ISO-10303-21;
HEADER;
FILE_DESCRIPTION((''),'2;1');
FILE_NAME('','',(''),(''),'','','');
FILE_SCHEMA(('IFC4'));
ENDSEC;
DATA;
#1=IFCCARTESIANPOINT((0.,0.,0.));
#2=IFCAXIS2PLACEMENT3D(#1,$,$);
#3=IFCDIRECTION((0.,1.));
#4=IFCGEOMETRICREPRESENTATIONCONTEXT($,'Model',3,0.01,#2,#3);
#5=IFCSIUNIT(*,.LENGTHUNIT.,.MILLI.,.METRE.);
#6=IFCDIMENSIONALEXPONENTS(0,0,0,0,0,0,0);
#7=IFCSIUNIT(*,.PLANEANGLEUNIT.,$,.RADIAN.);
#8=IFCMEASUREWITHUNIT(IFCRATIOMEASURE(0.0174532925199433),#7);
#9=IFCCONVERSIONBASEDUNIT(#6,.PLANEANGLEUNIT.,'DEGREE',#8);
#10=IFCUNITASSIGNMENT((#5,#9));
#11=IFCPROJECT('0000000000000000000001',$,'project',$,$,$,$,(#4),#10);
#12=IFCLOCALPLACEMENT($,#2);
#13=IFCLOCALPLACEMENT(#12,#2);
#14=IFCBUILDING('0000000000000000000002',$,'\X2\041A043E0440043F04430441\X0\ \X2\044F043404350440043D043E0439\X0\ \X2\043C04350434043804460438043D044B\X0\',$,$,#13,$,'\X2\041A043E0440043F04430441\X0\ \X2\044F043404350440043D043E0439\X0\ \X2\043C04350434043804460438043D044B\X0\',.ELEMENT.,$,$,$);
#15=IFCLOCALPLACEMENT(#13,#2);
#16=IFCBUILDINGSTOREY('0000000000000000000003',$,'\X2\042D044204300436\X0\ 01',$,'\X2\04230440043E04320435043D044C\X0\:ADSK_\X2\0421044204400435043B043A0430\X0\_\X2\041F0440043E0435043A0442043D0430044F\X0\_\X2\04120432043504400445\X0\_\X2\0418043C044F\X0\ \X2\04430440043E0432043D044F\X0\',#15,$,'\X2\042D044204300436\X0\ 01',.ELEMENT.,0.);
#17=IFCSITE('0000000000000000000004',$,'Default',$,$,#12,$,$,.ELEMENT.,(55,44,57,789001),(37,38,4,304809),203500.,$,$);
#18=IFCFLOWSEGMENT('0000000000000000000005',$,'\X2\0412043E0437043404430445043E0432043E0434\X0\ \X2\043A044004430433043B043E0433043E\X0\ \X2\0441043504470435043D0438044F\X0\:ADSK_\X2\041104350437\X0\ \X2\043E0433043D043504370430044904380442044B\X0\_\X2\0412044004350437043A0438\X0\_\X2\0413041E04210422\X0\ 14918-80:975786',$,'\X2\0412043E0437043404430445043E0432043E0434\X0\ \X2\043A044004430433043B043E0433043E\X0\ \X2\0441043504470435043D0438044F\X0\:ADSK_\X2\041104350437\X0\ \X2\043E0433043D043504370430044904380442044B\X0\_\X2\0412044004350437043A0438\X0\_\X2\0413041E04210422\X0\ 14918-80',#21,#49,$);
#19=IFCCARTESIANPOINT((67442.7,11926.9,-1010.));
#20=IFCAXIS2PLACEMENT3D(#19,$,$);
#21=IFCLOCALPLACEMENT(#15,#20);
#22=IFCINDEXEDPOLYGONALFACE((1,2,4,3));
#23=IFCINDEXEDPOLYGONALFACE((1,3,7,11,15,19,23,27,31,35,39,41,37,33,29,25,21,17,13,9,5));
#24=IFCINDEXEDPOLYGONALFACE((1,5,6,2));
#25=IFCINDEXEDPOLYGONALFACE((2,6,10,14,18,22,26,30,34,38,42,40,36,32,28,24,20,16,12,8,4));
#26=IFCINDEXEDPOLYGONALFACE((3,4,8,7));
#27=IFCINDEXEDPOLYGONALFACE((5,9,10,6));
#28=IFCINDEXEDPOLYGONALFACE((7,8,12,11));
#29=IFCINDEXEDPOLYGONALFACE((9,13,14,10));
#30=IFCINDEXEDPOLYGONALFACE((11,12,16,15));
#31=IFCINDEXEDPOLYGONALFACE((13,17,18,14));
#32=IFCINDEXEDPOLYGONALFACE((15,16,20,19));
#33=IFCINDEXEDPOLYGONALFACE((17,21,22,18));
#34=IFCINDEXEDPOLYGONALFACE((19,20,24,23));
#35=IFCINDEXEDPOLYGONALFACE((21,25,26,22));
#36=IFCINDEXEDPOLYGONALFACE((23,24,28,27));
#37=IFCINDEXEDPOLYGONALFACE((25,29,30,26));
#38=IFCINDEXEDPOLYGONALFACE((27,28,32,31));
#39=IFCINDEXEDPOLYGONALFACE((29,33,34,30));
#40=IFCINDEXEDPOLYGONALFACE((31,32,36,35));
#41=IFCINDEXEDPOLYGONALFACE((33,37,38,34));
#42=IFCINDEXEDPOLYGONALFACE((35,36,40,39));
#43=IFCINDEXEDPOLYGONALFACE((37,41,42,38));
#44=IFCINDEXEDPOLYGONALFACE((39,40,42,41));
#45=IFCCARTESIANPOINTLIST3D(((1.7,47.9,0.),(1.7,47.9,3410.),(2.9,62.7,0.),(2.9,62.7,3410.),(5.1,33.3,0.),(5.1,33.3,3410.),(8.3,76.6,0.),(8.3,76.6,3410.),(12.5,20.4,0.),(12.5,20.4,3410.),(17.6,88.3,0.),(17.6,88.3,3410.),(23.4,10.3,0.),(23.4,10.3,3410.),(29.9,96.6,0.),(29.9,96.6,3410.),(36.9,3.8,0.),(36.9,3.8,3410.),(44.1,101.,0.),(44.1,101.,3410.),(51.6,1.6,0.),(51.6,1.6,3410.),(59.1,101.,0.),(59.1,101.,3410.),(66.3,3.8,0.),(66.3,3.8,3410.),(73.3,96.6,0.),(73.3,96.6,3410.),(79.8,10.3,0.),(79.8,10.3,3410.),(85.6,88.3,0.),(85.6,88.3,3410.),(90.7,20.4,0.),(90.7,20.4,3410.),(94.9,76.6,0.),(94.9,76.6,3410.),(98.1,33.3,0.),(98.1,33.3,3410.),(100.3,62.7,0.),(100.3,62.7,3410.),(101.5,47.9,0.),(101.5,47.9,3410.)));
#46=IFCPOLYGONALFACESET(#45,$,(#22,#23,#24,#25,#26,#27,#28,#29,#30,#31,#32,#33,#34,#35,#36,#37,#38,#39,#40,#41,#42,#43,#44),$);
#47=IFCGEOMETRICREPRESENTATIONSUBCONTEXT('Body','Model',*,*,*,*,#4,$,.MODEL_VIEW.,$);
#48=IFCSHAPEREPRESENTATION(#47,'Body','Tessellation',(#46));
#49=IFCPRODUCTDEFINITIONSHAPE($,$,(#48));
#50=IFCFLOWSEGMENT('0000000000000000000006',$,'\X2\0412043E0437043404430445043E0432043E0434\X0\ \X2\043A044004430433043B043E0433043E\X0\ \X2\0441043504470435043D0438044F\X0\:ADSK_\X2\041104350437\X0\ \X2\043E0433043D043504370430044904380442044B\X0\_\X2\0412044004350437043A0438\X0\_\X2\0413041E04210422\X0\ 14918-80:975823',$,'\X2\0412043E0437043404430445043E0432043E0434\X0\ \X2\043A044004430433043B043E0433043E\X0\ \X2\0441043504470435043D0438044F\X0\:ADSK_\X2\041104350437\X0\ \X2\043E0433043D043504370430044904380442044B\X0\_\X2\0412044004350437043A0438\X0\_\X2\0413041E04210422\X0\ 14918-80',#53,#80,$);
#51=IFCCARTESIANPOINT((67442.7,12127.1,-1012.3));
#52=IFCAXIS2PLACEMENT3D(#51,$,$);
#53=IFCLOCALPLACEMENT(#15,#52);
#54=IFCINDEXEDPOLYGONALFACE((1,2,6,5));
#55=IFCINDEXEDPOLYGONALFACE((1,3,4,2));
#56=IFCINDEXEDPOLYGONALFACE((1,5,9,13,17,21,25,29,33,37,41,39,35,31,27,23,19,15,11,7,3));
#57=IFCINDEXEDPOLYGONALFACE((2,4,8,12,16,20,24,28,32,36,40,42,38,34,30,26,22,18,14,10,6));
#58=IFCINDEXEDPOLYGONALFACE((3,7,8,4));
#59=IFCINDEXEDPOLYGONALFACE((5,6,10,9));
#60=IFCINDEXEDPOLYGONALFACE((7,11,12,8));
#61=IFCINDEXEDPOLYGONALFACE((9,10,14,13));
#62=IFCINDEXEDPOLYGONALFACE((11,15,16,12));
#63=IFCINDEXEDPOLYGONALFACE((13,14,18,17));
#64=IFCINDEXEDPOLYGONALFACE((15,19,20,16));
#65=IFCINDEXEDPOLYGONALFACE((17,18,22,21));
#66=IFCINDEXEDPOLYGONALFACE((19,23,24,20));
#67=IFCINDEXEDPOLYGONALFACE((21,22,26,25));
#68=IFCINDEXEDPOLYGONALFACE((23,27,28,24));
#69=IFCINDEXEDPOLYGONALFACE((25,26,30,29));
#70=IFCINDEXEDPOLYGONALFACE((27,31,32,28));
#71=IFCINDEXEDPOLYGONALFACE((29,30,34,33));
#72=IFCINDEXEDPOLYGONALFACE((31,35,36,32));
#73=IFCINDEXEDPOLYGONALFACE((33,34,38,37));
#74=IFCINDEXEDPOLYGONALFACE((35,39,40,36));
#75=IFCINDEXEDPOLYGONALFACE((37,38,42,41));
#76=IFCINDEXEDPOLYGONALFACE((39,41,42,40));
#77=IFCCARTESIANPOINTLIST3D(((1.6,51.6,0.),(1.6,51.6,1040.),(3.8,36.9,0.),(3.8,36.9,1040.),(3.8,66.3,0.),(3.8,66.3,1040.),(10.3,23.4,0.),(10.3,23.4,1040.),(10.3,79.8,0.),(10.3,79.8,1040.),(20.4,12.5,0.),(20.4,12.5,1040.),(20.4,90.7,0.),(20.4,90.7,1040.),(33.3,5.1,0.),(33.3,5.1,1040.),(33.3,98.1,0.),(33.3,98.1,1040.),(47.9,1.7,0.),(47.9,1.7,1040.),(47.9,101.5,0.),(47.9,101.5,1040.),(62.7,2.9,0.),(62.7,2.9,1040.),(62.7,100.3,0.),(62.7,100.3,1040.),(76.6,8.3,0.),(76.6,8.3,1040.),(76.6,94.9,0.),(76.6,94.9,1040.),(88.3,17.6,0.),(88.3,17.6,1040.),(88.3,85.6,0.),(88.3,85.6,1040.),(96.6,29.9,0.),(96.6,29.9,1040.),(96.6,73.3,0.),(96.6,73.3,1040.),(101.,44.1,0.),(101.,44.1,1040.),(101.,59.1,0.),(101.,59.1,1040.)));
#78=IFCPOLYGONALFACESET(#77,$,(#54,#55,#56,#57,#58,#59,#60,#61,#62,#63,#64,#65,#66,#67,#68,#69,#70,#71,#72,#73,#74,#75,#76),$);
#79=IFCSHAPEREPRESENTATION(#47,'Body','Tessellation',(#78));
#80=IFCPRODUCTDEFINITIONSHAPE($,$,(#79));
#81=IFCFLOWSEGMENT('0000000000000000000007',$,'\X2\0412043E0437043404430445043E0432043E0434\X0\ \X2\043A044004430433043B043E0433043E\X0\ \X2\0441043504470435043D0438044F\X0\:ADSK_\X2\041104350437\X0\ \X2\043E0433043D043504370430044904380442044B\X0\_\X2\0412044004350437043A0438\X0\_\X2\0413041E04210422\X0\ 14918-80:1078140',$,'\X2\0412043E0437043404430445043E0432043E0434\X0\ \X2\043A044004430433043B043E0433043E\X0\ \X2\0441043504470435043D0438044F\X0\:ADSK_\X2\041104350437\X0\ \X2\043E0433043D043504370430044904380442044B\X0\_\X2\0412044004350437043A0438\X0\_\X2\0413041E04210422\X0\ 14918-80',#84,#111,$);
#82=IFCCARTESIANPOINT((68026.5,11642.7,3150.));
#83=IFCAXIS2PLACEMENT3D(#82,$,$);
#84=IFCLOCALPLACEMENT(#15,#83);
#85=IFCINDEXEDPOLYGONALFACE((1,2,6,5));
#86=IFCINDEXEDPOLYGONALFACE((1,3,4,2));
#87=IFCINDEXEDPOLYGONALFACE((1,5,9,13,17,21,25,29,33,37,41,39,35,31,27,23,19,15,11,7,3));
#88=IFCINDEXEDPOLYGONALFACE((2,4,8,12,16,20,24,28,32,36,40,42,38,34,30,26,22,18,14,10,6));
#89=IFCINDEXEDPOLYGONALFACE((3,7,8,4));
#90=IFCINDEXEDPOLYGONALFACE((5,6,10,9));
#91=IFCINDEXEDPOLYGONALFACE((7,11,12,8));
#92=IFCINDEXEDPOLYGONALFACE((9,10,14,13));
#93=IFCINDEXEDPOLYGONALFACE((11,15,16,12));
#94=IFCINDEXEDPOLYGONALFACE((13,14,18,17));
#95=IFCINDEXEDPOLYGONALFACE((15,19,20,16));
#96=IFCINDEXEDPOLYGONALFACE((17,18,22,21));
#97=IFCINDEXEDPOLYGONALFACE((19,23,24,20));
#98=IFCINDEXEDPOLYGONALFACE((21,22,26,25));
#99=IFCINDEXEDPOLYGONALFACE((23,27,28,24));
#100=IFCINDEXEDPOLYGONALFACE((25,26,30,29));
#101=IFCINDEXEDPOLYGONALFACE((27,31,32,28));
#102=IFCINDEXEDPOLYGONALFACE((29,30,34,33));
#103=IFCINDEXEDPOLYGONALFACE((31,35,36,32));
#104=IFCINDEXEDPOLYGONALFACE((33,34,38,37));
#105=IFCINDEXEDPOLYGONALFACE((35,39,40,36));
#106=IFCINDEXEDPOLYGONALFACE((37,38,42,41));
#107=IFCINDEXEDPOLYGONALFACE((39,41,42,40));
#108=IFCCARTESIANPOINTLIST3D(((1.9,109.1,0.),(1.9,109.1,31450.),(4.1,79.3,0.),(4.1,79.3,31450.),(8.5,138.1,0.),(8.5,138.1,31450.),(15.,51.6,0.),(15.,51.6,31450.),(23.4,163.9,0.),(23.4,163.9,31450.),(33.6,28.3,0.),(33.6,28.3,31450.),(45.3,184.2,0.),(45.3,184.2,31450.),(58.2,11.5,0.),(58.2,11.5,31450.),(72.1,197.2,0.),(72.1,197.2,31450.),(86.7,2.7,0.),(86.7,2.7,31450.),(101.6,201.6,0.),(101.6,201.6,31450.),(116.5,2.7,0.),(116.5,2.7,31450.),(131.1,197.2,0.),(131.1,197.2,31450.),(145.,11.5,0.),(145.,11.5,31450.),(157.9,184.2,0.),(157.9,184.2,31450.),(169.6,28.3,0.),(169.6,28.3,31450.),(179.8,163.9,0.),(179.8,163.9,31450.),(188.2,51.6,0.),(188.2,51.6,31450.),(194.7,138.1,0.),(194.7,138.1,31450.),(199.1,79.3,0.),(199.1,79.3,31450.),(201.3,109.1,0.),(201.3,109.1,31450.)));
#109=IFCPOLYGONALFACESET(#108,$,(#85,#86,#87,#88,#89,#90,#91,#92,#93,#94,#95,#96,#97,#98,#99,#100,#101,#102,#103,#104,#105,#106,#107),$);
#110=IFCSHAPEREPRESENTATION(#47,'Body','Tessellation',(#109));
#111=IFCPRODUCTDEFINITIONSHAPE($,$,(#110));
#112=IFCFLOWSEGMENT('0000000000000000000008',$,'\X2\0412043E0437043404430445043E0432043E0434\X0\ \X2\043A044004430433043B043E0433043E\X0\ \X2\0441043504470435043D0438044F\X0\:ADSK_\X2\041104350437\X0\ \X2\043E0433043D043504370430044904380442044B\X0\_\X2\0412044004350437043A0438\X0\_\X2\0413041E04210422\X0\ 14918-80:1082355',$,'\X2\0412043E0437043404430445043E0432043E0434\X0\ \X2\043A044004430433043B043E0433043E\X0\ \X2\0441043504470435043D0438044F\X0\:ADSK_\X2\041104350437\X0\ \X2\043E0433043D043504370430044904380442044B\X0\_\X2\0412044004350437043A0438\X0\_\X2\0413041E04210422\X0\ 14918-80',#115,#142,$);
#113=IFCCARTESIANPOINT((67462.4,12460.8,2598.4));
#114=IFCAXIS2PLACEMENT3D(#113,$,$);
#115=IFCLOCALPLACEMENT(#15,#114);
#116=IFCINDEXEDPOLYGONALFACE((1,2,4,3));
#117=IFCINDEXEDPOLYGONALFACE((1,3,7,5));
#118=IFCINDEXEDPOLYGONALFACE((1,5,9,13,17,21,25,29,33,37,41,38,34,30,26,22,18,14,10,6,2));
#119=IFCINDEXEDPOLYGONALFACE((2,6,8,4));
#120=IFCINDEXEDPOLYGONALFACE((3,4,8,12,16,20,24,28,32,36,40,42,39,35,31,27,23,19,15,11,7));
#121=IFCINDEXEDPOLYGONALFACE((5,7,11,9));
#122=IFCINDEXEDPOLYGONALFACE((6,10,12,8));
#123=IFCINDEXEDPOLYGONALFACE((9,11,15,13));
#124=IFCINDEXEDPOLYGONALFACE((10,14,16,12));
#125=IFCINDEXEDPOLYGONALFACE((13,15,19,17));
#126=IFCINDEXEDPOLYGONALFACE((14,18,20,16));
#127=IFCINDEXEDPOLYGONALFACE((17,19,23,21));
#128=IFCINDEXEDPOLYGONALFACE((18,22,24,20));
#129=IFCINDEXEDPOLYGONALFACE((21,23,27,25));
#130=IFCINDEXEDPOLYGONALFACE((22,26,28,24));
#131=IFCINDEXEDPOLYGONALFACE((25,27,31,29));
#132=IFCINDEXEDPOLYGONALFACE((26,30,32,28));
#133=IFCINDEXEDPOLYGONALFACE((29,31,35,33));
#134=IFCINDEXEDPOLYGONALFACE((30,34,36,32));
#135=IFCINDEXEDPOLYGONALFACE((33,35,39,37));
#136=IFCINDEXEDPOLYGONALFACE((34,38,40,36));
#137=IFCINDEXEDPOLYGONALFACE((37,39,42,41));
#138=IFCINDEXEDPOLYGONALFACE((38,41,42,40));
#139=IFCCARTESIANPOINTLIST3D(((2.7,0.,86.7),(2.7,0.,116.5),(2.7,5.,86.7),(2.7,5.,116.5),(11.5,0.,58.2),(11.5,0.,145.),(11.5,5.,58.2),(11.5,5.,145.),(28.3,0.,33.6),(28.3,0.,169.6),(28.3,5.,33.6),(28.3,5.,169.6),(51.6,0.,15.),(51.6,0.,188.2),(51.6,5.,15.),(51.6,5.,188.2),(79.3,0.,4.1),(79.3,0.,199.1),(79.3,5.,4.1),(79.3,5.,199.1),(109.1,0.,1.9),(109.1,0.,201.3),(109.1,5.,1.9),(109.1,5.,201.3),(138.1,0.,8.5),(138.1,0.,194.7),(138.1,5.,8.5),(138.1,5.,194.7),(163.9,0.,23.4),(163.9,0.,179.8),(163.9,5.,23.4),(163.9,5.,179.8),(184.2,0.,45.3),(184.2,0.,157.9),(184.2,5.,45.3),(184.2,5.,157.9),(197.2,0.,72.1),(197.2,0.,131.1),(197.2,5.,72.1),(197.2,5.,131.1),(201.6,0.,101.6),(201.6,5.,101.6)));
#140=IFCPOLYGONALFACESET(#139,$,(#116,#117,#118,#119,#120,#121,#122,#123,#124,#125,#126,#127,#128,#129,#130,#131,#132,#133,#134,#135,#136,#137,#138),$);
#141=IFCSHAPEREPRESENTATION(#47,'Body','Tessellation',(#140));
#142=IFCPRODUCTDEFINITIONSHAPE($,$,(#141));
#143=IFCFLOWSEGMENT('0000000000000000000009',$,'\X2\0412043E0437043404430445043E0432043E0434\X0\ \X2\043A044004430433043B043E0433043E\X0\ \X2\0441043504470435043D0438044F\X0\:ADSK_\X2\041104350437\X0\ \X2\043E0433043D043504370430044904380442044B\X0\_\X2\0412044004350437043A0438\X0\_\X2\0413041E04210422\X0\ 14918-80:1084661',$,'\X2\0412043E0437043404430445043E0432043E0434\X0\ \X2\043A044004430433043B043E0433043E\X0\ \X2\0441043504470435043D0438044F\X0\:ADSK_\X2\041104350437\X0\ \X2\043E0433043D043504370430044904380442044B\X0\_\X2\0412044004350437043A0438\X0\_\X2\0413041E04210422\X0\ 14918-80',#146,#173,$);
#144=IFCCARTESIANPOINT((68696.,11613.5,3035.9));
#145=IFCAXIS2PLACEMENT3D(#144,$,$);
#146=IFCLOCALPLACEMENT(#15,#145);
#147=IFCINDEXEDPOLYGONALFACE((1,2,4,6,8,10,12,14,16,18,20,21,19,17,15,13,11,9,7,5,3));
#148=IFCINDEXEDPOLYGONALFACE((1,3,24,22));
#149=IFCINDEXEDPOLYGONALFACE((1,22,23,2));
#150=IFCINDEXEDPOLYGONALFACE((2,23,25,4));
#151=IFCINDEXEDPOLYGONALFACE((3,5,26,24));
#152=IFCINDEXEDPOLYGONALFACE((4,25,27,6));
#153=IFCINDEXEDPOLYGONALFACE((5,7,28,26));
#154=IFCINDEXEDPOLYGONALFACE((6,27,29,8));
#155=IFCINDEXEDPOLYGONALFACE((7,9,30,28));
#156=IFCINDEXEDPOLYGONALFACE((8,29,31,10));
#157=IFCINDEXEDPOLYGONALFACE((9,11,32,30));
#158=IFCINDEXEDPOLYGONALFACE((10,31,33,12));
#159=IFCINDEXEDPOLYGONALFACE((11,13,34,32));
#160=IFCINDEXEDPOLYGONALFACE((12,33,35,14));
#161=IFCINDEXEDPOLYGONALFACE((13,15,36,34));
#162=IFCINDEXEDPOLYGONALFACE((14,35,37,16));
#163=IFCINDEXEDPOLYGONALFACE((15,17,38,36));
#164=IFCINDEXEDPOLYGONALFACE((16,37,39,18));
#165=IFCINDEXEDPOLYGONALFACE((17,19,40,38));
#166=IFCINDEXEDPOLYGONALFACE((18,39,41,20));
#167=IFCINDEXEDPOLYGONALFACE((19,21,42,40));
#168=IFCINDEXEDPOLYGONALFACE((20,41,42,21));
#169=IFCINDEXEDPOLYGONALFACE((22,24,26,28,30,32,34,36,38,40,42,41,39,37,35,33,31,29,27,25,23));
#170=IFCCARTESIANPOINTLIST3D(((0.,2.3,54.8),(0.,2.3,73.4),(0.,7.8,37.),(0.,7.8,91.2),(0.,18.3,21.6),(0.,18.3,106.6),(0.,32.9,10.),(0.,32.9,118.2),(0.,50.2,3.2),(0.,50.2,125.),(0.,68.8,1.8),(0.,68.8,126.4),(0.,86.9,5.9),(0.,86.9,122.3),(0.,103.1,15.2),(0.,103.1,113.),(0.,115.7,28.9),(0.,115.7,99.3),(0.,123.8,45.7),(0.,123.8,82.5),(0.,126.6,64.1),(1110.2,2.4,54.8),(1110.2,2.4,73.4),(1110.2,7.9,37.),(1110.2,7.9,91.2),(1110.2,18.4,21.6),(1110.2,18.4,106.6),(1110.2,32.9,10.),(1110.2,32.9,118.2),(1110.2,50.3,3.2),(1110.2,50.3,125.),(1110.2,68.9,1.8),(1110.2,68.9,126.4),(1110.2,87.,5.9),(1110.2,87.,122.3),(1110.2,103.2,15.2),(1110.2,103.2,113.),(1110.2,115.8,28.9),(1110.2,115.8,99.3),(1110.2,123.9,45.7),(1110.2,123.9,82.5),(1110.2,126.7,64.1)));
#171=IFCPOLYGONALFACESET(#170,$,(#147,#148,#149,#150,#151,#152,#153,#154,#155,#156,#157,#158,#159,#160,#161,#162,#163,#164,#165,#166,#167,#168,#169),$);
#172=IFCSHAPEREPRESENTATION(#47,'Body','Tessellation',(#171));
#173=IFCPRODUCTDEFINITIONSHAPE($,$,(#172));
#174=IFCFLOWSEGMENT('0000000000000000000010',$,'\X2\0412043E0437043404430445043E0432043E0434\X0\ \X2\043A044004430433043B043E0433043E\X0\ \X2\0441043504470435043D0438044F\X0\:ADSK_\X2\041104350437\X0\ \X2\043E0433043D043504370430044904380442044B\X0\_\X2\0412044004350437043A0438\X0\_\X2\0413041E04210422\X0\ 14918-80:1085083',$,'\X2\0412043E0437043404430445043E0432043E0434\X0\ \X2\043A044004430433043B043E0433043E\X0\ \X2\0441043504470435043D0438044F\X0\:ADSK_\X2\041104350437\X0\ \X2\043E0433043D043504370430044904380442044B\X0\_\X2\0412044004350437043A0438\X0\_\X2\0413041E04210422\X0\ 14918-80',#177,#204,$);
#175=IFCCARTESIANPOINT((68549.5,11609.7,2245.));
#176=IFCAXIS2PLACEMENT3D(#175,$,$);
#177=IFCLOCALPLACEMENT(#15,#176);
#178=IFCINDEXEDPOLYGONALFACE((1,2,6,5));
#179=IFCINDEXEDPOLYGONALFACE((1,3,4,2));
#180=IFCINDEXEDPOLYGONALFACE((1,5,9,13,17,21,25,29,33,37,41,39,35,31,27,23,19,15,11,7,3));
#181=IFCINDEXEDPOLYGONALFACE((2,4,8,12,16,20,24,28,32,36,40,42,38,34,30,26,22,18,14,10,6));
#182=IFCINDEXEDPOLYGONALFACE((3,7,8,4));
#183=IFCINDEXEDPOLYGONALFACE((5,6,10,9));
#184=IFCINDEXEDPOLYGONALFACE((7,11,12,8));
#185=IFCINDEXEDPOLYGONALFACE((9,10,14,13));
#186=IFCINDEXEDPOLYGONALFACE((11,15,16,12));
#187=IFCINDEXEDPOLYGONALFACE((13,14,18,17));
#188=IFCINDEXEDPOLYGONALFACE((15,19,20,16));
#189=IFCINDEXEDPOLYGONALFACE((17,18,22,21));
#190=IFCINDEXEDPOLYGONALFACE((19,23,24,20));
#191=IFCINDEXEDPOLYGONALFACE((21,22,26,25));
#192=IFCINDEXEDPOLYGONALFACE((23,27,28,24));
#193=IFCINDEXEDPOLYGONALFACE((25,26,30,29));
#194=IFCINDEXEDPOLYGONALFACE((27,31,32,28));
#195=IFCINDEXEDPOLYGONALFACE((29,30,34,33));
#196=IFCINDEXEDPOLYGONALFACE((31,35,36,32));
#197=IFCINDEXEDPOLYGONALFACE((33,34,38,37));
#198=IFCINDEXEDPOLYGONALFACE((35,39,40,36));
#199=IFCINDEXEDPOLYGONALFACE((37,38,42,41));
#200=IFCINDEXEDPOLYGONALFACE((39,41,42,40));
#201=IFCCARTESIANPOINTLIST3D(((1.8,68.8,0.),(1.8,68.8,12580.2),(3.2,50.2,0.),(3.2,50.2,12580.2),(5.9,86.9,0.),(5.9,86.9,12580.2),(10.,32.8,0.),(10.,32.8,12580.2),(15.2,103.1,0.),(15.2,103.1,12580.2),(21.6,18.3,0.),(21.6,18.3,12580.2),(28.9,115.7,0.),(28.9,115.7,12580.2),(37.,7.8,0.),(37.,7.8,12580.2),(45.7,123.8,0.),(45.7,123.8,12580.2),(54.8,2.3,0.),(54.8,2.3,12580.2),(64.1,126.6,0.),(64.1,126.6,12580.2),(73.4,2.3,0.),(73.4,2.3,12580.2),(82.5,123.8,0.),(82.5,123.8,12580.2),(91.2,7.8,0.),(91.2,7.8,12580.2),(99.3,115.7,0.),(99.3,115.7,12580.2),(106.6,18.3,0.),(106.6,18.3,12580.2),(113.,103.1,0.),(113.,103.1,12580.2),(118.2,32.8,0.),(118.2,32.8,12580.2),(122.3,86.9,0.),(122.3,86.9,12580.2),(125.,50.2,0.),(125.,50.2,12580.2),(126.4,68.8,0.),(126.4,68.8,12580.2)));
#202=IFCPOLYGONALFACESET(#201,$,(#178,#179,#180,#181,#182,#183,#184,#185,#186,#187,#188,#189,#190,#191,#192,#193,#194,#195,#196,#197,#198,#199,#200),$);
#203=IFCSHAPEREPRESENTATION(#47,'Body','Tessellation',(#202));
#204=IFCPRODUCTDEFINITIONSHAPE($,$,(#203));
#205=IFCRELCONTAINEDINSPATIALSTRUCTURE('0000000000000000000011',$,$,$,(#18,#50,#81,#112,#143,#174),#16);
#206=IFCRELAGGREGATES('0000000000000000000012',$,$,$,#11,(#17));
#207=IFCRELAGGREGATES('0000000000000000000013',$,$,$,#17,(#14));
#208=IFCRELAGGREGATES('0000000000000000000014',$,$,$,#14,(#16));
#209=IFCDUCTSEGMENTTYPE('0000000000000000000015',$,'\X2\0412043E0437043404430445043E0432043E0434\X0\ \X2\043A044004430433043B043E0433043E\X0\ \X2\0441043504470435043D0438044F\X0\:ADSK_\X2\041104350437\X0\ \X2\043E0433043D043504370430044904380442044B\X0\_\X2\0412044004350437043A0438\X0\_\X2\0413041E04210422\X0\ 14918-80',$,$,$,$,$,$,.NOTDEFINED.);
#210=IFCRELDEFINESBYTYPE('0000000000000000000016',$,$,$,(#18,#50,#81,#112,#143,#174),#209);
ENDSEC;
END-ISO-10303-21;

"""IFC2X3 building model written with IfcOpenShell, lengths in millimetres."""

from ifc_helpers import new_model, entity, si_unit, converted_unit, direction, frame, origin, origin_2d_with_axis, place, context, subcontext, project, spatial, circle, extrude, type_object, element, save


model = new_model("IFC2X3")

# Units and contexts
model_context = context("Model", 3, precision=0.01, world=origin(), true_north=direction((0.0, 1.0)))
body_context = subcontext(model_context, "Body", "Model", "MODEL_VIEW")
ifc_project = project(units=[si_unit("LENGTHUNIT", "METRE", prefix="MILLI"), converted_unit("PLANEANGLEUNIT", "DEGREE", entity("IfcRatioMeasure", 0.0174532925199433), si_unit("PLANEANGLEUNIT", "RADIAN"), dimensions=[0, 0, 0, 0, 0, 0, 0])], contexts=[model_context])

# Site, building, storey
site_placement = place(None, origin())
site = spatial("IfcSite", under=ifc_project, at=site_placement, Name="Default", CompositionType="ELEMENT", RefLatitude=(55, 44, 57, 789001), RefLongitude=(37, 38, 4, 304809), RefElevation=203500.0)
building_placement = place(site_placement, origin())
building = spatial("IfcBuilding", under=site, at=building_placement, Name="Корпус ядерной медицины", LongName="Корпус ядерной медицины", CompositionType="ELEMENT")
storey_placement = place(building_placement, origin())
storey = spatial("IfcBuildingStorey", under=building, at=storey_placement, Name="Этаж 01", ObjectType="Уровень:ADSK_Стрелка_Проектная_Вверх_Имя уровня", LongName="Этаж 01", CompositionType="ELEMENT", Elevation=0.0)

# Flow segments
duct_segment_type_1 = type_object("IfcDuctSegmentType", Name="Воздуховод круглого сечения:ADSK_Без огнезащиты_Врезки_ГОСТ 14918-80", PredefinedType="NOTDEFINED")
flow_segment_1_placement = place(storey_placement, frame((67442.7, 11926.9, -1010.0)))
element("IfcFlowSegment", 1, at=flow_segment_1_placement, inside=storey, type_object=duct_segment_type_1, Name="Воздуховод круглого сечения:ADSK_Без огнезащиты_Врезки_ГОСТ 14918-80:975786", ObjectType="Воздуховод круглого сечения:ADSK_Без огнезащиты_Врезки_ГОСТ 14918-80", context=body_context, shape_type="SweptSolid", body=[
    extrude(circle(Radius=50.0, at=origin_2d_with_axis()), frame((51.6, 51.6, 0.0), z_axis=(0.0, 0.0, 1.0), x_axis=(0.0, -1.0, 0.0)), (0.0, 0.0, 1.0), 3410.0),
])
flow_segment_2_placement = place(storey_placement, frame((67442.7, 12127.1, -1012.3)))
element("IfcFlowSegment", 2, at=flow_segment_2_placement, inside=storey, type_object=duct_segment_type_1, Name="Воздуховод круглого сечения:ADSK_Без огнезащиты_Врезки_ГОСТ 14918-80:975823", ObjectType="Воздуховод круглого сечения:ADSK_Без огнезащиты_Врезки_ГОСТ 14918-80", context=body_context, shape_type="SweptSolid", body=[
    extrude(circle(Radius=50.0, at=origin_2d_with_axis()), frame((51.6, 51.6, 0.0), z_axis=(0.0, 0.0, 1.0), x_axis=(-1.0, 0.0, 0.0)), (0.0, 0.0, 1.0), 1040.0),
])
flow_segment_3_placement = place(storey_placement, frame((68026.5, 11642.7, 3150.0)))
element("IfcFlowSegment", 3, at=flow_segment_3_placement, inside=storey, type_object=duct_segment_type_1, Name="Воздуховод круглого сечения:ADSK_Без огнезащиты_Врезки_ГОСТ 14918-80:1078140", ObjectType="Воздуховод круглого сечения:ADSK_Без огнезащиты_Врезки_ГОСТ 14918-80", context=body_context, shape_type="SweptSolid", body=[
    extrude(circle(Radius=100.0, at=origin_2d_with_axis()), frame((101.6, 101.6, 0.0), z_axis=(0.0, 0.0, 1.0), x_axis=(0.0, 1.0, 0.0)), (0.0, 0.0, 1.0), 31450.0),
])
flow_segment_4_placement = place(storey_placement, frame((67462.4, 12460.8, 2598.4)))
element("IfcFlowSegment", 4, at=flow_segment_4_placement, inside=storey, type_object=duct_segment_type_1, Name="Воздуховод круглого сечения:ADSK_Без огнезащиты_Врезки_ГОСТ 14918-80:1082355", ObjectType="Воздуховод круглого сечения:ADSK_Без огнезащиты_Врезки_ГОСТ 14918-80", context=body_context, shape_type="SweptSolid", body=[
    extrude(circle(Radius=100.0, at=origin_2d_with_axis()), frame((101.6, 0.0, 101.6), z_axis=(0.0, 1.0, 0.0), x_axis=(1.0, 0.0, 0.0)), (0.0, 0.0, 1.0), 5.0),
])
flow_segment_5_placement = place(storey_placement, frame((68696.0, 11613.5, 3035.9)))
element("IfcFlowSegment", 5, at=flow_segment_5_placement, inside=storey, type_object=duct_segment_type_1, Name="Воздуховод круглого сечения:ADSK_Без огнезащиты_Врезки_ГОСТ 14918-80:1084661", ObjectType="Воздуховод круглого сечения:ADSK_Без огнезащиты_Врезки_ГОСТ 14918-80", context=body_context, shape_type="SweptSolid", body=[
    extrude(circle(Radius=62.5, at=origin_2d_with_axis()), frame((0.0, 64.1, 64.1), z_axis=(1.0, 0.000088, 0.0), x_axis=(-0.000088, 1.0, 0.0)), (0.0, 0.0, 1.0), 1110.2),
])
flow_segment_6_placement = place(storey_placement, frame((68549.5, 11609.7, 2245.0)))
element("IfcFlowSegment", 6, at=flow_segment_6_placement, inside=storey, type_object=duct_segment_type_1, Name="Воздуховод круглого сечения:ADSK_Без огнезащиты_Врезки_ГОСТ 14918-80:1085083", ObjectType="Воздуховод круглого сечения:ADSK_Без огнезащиты_Врезки_ГОСТ 14918-80", context=body_context, shape_type="SweptSolid", body=[
    extrude(circle(Radius=62.5, at=origin_2d_with_axis()), frame((64.1, 64.1, 0.0), z_axis=(0.0, 0.0, 1.0), x_axis=(0.0, 1.0, 0.0)), (0.0, 0.0, 1.0), 12580.2),
])

save(model, "model.ifc")
